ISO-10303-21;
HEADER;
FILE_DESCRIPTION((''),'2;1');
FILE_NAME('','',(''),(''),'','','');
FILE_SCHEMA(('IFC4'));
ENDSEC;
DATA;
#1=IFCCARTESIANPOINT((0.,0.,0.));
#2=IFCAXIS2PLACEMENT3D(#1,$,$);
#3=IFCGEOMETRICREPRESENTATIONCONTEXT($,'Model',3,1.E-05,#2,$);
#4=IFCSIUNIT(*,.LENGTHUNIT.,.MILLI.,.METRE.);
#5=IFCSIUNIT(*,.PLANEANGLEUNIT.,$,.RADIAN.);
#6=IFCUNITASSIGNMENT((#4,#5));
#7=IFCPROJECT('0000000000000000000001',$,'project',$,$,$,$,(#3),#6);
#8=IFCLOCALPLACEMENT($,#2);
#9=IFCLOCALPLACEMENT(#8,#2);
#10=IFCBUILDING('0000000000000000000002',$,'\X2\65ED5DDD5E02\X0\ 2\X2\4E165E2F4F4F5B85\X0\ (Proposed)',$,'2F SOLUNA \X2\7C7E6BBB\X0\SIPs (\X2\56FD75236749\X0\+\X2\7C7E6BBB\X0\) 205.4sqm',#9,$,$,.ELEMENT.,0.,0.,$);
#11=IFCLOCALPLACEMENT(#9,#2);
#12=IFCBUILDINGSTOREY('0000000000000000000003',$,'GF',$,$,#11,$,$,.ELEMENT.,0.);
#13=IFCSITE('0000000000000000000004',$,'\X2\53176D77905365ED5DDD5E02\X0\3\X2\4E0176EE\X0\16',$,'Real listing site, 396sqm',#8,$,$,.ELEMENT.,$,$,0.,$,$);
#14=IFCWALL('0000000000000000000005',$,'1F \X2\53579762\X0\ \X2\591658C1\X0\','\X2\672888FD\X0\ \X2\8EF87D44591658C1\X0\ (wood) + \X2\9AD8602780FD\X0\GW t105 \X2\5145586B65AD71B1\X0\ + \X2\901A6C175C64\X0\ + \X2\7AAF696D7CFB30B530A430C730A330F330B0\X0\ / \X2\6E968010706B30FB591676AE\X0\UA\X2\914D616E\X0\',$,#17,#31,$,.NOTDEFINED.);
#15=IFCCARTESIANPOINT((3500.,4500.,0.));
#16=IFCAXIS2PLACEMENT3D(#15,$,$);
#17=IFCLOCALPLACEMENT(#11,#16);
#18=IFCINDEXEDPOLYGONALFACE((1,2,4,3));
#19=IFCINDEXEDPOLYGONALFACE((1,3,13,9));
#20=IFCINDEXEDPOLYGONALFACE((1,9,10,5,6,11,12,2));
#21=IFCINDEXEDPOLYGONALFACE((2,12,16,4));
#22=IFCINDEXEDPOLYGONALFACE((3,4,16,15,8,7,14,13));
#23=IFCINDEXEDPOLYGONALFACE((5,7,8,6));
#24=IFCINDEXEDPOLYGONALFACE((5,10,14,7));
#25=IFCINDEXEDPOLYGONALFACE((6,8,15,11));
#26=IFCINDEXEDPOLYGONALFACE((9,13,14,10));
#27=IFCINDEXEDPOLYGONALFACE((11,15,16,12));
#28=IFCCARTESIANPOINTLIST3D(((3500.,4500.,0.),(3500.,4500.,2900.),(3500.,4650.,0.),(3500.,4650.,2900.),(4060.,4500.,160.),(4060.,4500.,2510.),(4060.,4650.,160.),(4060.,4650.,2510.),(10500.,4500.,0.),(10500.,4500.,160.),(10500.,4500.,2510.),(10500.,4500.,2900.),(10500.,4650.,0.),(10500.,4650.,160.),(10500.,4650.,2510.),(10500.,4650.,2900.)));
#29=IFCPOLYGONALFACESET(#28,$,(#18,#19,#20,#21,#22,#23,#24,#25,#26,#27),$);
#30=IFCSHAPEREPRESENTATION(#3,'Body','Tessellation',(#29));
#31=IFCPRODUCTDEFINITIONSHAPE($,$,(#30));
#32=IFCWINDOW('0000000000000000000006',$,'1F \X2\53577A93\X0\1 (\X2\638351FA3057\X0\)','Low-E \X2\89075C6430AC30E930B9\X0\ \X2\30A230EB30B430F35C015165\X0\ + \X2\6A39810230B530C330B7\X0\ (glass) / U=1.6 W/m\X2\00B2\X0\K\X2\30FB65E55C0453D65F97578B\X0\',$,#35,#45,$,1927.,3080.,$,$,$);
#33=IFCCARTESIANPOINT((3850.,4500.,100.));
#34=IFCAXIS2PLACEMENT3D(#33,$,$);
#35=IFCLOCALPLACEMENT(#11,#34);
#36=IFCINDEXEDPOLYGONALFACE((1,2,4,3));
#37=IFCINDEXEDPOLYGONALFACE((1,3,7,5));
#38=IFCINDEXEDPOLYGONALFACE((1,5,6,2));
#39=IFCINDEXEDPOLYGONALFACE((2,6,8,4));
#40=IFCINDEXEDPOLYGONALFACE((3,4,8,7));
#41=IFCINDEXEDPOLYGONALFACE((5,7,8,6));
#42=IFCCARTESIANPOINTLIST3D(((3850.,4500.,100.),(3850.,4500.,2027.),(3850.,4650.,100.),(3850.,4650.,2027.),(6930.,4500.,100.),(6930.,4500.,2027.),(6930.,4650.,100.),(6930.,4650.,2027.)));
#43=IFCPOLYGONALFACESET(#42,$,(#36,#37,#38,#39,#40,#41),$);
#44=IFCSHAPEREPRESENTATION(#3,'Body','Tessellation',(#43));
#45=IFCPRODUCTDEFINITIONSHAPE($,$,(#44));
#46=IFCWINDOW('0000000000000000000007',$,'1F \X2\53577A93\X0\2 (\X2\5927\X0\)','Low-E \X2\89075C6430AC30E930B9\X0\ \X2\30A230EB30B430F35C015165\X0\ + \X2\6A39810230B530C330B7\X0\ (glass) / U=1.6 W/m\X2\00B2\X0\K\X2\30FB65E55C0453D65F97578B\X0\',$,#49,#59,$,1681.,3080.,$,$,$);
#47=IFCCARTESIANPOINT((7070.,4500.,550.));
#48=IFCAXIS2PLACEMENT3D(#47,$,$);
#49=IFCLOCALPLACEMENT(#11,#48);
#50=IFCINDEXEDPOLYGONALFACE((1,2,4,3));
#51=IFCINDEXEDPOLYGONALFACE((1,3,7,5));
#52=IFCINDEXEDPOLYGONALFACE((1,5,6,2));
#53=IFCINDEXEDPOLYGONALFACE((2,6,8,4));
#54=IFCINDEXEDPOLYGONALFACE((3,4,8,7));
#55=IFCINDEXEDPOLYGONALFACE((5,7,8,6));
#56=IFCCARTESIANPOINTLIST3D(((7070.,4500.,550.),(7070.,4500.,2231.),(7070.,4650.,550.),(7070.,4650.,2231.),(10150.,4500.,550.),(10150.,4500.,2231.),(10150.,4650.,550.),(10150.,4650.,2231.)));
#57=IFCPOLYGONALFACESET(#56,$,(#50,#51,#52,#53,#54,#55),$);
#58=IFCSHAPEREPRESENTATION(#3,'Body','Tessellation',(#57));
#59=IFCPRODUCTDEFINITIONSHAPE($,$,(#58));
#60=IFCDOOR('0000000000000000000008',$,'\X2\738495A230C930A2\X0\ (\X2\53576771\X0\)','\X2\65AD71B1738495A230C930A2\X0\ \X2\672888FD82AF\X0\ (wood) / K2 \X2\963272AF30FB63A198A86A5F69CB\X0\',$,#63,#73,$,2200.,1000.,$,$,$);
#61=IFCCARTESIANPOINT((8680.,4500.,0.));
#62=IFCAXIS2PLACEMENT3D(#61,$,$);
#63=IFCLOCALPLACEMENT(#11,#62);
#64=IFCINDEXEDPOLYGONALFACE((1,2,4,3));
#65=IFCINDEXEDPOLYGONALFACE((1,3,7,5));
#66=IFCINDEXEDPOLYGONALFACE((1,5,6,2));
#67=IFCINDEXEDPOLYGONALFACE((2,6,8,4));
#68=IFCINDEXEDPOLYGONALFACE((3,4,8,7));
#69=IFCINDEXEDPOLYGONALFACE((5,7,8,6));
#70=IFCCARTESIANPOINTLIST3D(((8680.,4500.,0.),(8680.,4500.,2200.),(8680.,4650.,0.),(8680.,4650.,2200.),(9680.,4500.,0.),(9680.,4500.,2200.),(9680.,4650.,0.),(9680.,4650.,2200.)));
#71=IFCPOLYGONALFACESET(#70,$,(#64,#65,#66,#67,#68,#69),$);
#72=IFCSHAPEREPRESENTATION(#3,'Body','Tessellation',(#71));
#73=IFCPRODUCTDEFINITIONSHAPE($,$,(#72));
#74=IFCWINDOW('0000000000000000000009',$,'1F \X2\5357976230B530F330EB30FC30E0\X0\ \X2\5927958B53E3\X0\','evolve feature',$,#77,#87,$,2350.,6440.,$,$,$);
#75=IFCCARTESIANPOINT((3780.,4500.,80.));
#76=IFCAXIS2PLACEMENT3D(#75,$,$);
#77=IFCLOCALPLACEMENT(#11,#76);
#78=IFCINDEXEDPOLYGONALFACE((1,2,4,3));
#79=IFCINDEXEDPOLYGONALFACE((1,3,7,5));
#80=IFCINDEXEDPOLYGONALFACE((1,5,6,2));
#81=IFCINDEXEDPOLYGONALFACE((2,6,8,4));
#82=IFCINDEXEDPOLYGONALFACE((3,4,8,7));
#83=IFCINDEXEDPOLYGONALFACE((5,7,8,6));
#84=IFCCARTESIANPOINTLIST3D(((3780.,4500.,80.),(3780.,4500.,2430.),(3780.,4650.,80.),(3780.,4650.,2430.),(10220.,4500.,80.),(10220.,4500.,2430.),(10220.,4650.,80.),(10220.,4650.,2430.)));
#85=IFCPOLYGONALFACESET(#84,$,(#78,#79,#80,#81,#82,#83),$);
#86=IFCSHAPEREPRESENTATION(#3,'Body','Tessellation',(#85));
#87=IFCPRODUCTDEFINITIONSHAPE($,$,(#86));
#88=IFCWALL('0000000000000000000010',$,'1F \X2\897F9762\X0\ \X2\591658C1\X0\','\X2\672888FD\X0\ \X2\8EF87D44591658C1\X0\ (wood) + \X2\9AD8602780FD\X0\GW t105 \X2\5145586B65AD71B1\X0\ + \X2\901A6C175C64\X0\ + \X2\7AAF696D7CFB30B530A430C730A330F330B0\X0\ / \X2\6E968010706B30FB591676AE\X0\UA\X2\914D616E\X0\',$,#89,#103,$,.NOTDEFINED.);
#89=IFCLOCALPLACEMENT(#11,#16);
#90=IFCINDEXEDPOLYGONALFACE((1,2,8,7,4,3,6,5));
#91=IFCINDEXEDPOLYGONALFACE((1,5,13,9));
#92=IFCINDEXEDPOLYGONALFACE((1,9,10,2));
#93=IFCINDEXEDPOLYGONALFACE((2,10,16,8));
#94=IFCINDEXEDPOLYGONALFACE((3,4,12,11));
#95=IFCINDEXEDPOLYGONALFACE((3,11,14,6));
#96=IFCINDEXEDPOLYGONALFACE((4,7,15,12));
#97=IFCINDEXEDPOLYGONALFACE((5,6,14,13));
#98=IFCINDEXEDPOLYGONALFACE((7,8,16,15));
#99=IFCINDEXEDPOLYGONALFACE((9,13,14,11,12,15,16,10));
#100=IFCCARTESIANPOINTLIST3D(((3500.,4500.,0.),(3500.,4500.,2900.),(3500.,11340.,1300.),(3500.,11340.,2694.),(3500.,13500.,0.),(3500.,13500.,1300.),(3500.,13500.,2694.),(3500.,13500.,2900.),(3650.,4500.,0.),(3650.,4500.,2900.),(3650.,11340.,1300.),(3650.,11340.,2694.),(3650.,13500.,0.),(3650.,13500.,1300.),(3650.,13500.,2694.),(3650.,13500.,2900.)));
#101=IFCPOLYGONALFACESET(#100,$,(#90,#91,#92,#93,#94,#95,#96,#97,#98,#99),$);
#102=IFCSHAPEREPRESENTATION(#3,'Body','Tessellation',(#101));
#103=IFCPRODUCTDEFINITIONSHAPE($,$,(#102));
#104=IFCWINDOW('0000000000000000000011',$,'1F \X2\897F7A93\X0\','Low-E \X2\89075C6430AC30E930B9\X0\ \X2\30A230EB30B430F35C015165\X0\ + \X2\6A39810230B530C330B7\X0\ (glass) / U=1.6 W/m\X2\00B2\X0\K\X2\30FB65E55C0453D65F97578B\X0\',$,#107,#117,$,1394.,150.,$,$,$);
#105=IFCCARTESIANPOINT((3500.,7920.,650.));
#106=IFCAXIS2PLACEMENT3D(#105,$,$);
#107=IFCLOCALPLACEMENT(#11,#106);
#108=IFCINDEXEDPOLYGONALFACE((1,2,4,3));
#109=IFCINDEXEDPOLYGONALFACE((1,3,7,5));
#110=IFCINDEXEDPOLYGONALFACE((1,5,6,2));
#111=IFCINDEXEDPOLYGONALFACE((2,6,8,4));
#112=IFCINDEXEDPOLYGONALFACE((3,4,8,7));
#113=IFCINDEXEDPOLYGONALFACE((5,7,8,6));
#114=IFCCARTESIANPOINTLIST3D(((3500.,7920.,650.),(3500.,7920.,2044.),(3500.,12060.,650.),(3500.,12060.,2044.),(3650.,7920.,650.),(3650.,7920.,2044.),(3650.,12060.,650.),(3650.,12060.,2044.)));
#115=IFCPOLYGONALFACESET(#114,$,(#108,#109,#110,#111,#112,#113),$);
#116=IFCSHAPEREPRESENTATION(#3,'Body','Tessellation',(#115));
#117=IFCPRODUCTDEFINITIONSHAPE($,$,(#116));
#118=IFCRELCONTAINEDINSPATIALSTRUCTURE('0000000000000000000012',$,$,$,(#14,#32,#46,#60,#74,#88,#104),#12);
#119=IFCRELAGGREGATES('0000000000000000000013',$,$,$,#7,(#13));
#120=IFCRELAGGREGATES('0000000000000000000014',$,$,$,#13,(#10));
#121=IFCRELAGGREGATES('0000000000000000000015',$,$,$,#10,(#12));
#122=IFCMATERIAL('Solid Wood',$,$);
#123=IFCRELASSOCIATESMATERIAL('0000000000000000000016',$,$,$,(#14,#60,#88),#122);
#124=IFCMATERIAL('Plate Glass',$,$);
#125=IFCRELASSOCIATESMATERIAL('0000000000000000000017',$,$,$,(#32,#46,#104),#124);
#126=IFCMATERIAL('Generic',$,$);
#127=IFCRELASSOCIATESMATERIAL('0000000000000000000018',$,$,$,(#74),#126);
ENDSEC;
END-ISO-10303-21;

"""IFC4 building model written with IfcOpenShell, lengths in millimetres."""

from ifc_helpers import new_model, si_unit, frame, frame_2d, origin, place, context, project, spatial, rectangle, extrude, material, element, fill, save


model = new_model("IFC4")

# Units and contexts
model_context = context("Model", 3, precision=1e-05, world=origin())
ifc_project = project(units=[si_unit("LENGTHUNIT", "METRE", prefix="MILLI"), si_unit("PLANEANGLEUNIT", "RADIAN")], contexts=[model_context])

# Site, building, storey
site_placement = place(None, origin())
site = spatial("IfcSite", under=ifc_project, at=site_placement, Name="北海道旭川市3丁目16", ObjectType="Real listing site, 396sqm", CompositionType="ELEMENT", RefElevation=0.0)
building_placement = place(site_placement, origin())
building = spatial("IfcBuilding", under=site, at=building_placement, Name="旭川市 2世帯住宅 (Proposed)", ObjectType="2F SOLUNA 籾殻SIPs (国産杉+籾殻) 205.4sqm", CompositionType="ELEMENT", ElevationOfRefHeight=0.0, ElevationOfTerrain=0.0)
storey_placement = place(building_placement, origin())
storey = spatial("IfcBuildingStorey", under=building, at=storey_placement, Name="GF", CompositionType="ELEMENT", Elevation=0.0)

# Shared definitions
ifc_material_1 = material(Name="Solid Wood")
ifc_material_2 = material(Name="Generic")

# Wall, openings, windows, door
wall_1_placement = place(storey_placement, frame((3500.0, 4500.0, 0.0)))
wall_1 = element("IfcWall", 1, at=wall_1_placement, inside=storey, material=ifc_material_1, Name="1F 南面 外壁", Description="木製 軸組外壁 (wood) + 高性能GW t105 充填断熱 + 通気層 + 窯業系サイディング / 準耐火・外皮UA配慮", PredefinedType="NOTDEFINED", context=model_context, shape_type="SweptSolid", body=[
    extrude(rectangle(XDim=7000.0, YDim=150.0, at=frame_2d((3500.0, 75.0))), frame((3500.0, 4500.0, 0.0)), (0.0, 0.0, 1.0), 2900.0),
])
opening_1_placement = place(storey_placement, frame((3850.0, 4500.0, 100.0)))
opening_1 = element("IfcOpeningElement", 2, at=opening_1_placement, cuts=wall_1, PredefinedType="NOTDEFINED", context=model_context, shape_type="SweptSolid", body=[
    extrude(rectangle(XDim=3080.0, YDim=150.0, at=frame_2d((1540.0, 75.0))), frame((3850.0, 4500.0, 100.0)), (0.0, 0.0, 1.0), 1927.0),
])
opening_2_placement = place(storey_placement, frame((7070.0, 4500.0, 550.0)))
opening_2 = element("IfcOpeningElement", 3, at=opening_2_placement, cuts=wall_1, PredefinedType="NOTDEFINED", context=model_context, shape_type="SweptSolid", body=[
    extrude(rectangle(XDim=3080.0, YDim=150.0, at=frame_2d((1540.0, 75.0))), frame((7070.0, 4500.0, 550.0)), (0.0, 0.0, 1.0), 1681.0),
])
opening_3_placement = place(storey_placement, frame((8680.0, 4500.0, 0.0)))
opening_3 = element("IfcOpeningElement", 4, at=opening_3_placement, cuts=wall_1, PredefinedType="NOTDEFINED", context=model_context, shape_type="SweptSolid", body=[
    extrude(rectangle(XDim=1000.0, YDim=150.0, at=frame_2d((500.0, 75.0))), frame((8680.0, 4500.0, 0.0)), (0.0, 0.0, 1.0), 2200.0),
])
opening_4_placement = place(storey_placement, frame((3780.0, 4500.0, 80.0)))
opening_4 = element("IfcOpeningElement", 5, at=opening_4_placement, cuts=wall_1, PredefinedType="NOTDEFINED", context=model_context, shape_type="SweptSolid", body=[
    extrude(rectangle(XDim=6440.0, YDim=150.0, at=frame_2d((3220.0, 75.0))), frame((3780.0, 4500.0, 80.0)), (0.0, 0.0, 1.0), 2350.0),
])
ifc_material_3 = material(Name="Plate Glass")
window_1_placement = place(storey_placement, frame((3850.0, 4500.0, 100.0)))
window_1 = element("IfcWindow", 6, at=window_1_placement, inside=storey, material=ifc_material_3, Name="1F 南窓1 (掃出し)", Description="Low-E 複層ガラス アルゴン封入 + 樹脂サッシ (glass) / U=1.6 W/m²K・日射取得型", OverallHeight=1927.0, OverallWidth=3080.0, context=model_context, shape_type="SweptSolid", body=[
    extrude(rectangle(XDim=3080.0, YDim=150.0, at=frame_2d((1540.0, 75.0))), frame((3850.0, 4500.0, 100.0)), (0.0, 0.0, 1.0), 1927.0),
])
fill(opening_1, window_1)
window_2_placement = place(storey_placement, frame((7070.0, 4500.0, 550.0)))
window_2 = element("IfcWindow", 7, at=window_2_placement, inside=storey, material=ifc_material_3, Name="1F 南窓2 (大)", Description="Low-E 複層ガラス アルゴン封入 + 樹脂サッシ (glass) / U=1.6 W/m²K・日射取得型", OverallHeight=1681.0, OverallWidth=3080.0, context=model_context, shape_type="SweptSolid", body=[
    extrude(rectangle(XDim=3080.0, YDim=150.0, at=frame_2d((1540.0, 75.0))), frame((7070.0, 4500.0, 550.0)), (0.0, 0.0, 1.0), 1681.0),
])
fill(opening_2, window_2)
door_placement = place(storey_placement, frame((8680.0, 4500.0, 0.0)))
door = element("IfcDoor", 8, at=door_placement, inside=storey, material=ifc_material_1, Name="玄関ドア (南東)", Description="断熱玄関ドア 木製芯 (wood) / K2 防犯・採風機構", OverallHeight=2200.0, OverallWidth=1000.0, context=model_context, shape_type="SweptSolid", body=[
    extrude(rectangle(XDim=1000.0, YDim=150.0, at=frame_2d((500.0, 75.0))), frame((8680.0, 4500.0, 0.0)), (0.0, 0.0, 1.0), 2200.0),
])
fill(opening_3, door)
window_3_placement = place(storey_placement, frame((3780.0, 4500.0, 80.0)))
window_3 = element("IfcWindow", 9, at=window_3_placement, inside=storey, material=ifc_material_2, Name="1F 南面サンルーム 大開口", Description="evolve feature", OverallHeight=2350.0, OverallWidth=6440.0, context=model_context, shape_type="SweptSolid", body=[
    extrude(rectangle(XDim=6440.0, YDim=150.0, at=frame_2d((3220.0, 75.0))), frame((3780.0, 4500.0, 80.0)), (0.0, 0.0, 1.0), 2350.0),
])
fill(opening_4, window_3)

# Wall, opening, window
wall_2_placement = place(storey_placement, frame((3500.0, 4500.0, 0.0)))
wall_2 = element("IfcWall", 10, at=wall_2_placement, inside=storey, material=ifc_material_1, Name="1F 西面 外壁", Description="木製 軸組外壁 (wood) + 高性能GW t105 充填断熱 + 通気層 + 窯業系サイディング / 準耐火・外皮UA配慮", PredefinedType="NOTDEFINED", context=model_context, shape_type="SweptSolid", body=[
    extrude(rectangle(XDim=150.0, YDim=9000.0, at=frame_2d((75.0, 4500.0))), frame((3500.0, 4500.0, 0.0)), (0.0, 0.0, 1.0), 2900.0),
])
opening_5_placement = place(storey_placement, frame((3500.0, 7920.0, 650.0)))
opening_5 = element("IfcOpeningElement", 11, at=opening_5_placement, cuts=wall_2, PredefinedType="NOTDEFINED", context=model_context, shape_type="SweptSolid", body=[
    extrude(rectangle(XDim=150.0, YDim=4140.0, at=frame_2d((75.0, 2070.0))), frame((3500.0, 7920.0, 650.0)), (0.0, 0.0, 1.0), 1394.0),
])
window_4_placement = place(storey_placement, frame((3500.0, 7920.0, 650.0)))
window_4 = element("IfcWindow", 12, at=window_4_placement, inside=storey, material=ifc_material_3, Name="1F 西窓", Description="Low-E 複層ガラス アルゴン封入 + 樹脂サッシ (glass) / U=1.6 W/m²K・日射取得型", OverallHeight=1394.0, OverallWidth=150.0, context=model_context, shape_type="SweptSolid", body=[
    extrude(rectangle(XDim=150.0, YDim=4140.0, at=frame_2d((75.0, 2070.0))), frame((3500.0, 7920.0, 650.0)), (0.0, 0.0, 1.0), 1394.0),
])
fill(opening_5, window_4)

save(model, "model.ifc")
